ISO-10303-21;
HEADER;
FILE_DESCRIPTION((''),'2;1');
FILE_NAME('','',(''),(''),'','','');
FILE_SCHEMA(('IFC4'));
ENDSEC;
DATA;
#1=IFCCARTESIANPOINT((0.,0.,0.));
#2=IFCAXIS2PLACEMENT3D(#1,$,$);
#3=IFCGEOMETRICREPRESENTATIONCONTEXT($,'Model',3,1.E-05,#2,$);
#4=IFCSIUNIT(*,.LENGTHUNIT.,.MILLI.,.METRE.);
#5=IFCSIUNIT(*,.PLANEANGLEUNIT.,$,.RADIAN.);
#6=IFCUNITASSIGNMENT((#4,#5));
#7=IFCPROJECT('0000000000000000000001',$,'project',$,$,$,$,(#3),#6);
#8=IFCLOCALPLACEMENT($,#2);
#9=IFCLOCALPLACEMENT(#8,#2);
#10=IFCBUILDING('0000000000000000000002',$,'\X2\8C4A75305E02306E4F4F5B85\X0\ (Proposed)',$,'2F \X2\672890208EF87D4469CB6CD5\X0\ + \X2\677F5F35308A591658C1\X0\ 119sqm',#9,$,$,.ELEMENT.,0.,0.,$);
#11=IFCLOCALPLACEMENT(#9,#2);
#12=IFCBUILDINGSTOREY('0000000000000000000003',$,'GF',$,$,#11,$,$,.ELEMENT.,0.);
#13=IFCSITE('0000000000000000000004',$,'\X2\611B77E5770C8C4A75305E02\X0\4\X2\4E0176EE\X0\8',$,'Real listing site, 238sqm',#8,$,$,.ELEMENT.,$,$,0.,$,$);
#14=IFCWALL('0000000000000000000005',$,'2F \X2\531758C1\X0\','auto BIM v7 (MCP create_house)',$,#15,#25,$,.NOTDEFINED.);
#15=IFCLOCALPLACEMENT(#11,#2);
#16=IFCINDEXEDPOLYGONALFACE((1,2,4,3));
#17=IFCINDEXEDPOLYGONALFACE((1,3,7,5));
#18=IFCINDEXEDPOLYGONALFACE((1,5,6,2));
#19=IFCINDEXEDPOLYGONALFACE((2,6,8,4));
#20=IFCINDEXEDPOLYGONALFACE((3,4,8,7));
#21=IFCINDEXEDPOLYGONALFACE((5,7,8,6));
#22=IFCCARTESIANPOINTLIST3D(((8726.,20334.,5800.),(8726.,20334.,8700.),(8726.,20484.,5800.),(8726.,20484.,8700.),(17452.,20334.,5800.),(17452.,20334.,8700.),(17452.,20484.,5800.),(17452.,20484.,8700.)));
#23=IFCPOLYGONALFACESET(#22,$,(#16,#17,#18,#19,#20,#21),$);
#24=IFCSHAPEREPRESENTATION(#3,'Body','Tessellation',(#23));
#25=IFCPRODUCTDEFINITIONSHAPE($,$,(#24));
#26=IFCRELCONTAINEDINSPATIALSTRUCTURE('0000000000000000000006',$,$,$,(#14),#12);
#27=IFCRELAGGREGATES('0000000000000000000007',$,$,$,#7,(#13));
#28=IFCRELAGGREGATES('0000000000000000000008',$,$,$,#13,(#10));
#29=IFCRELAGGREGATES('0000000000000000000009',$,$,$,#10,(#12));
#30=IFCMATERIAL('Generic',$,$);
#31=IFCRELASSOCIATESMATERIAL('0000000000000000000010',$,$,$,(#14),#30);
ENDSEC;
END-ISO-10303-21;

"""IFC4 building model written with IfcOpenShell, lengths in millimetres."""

from ifc_helpers import new_model, si_unit, frame, frame_2d, origin, place, context, project, spatial, rectangle, extrude, material, element, save


model = new_model("IFC4")

# Units and contexts
model_context = context("Model", 3, precision=1e-05, world=origin())
ifc_project = project(units=[si_unit("LENGTHUNIT", "METRE", prefix="MILLI"), si_unit("PLANEANGLEUNIT", "RADIAN")], contexts=[model_context])

# Site, building, storey
site_placement = place(None, origin())
site = spatial("IfcSite", under=ifc_project, at=site_placement, Name="愛知県豊田市4丁目8", ObjectType="Real listing site, 238sqm", CompositionType="ELEMENT", RefElevation=0.0)
building_placement = place(site_placement, origin())
building = spatial("IfcBuilding", under=site, at=building_placement, Name="豊田市の住宅 (Proposed)", ObjectType="2F 木造軸組構法 + 板張り外壁 119sqm", CompositionType="ELEMENT", ElevationOfRefHeight=0.0, ElevationOfTerrain=0.0)
storey_placement = place(building_placement, origin())
storey = spatial("IfcBuildingStorey", under=building, at=storey_placement, Name="GF", CompositionType="ELEMENT", Elevation=0.0)

# Shared definitions
ifc_material = material(Name="Generic")

# Wall
wall_1_placement = place(storey_placement, frame((4363.0, 10167.0, 2900.0)))
element("IfcWall", 1, at=wall_1_placement, inside=storey, material=ifc_material, Name="2F 北壁", Description="auto BIM v7 (MCP create_house)", PredefinedType="NOTDEFINED", context=model_context, shape_type="SweptSolid", body=[
    extrude(rectangle(XDim=8726.0, YDim=150.0, at=frame_2d((4363.0, 75.0))), frame((4363.0, 10167.0, 2900.0)), (0.0, 0.0, 1.0), 2900.0),
])

save(model, "model.ifc")
